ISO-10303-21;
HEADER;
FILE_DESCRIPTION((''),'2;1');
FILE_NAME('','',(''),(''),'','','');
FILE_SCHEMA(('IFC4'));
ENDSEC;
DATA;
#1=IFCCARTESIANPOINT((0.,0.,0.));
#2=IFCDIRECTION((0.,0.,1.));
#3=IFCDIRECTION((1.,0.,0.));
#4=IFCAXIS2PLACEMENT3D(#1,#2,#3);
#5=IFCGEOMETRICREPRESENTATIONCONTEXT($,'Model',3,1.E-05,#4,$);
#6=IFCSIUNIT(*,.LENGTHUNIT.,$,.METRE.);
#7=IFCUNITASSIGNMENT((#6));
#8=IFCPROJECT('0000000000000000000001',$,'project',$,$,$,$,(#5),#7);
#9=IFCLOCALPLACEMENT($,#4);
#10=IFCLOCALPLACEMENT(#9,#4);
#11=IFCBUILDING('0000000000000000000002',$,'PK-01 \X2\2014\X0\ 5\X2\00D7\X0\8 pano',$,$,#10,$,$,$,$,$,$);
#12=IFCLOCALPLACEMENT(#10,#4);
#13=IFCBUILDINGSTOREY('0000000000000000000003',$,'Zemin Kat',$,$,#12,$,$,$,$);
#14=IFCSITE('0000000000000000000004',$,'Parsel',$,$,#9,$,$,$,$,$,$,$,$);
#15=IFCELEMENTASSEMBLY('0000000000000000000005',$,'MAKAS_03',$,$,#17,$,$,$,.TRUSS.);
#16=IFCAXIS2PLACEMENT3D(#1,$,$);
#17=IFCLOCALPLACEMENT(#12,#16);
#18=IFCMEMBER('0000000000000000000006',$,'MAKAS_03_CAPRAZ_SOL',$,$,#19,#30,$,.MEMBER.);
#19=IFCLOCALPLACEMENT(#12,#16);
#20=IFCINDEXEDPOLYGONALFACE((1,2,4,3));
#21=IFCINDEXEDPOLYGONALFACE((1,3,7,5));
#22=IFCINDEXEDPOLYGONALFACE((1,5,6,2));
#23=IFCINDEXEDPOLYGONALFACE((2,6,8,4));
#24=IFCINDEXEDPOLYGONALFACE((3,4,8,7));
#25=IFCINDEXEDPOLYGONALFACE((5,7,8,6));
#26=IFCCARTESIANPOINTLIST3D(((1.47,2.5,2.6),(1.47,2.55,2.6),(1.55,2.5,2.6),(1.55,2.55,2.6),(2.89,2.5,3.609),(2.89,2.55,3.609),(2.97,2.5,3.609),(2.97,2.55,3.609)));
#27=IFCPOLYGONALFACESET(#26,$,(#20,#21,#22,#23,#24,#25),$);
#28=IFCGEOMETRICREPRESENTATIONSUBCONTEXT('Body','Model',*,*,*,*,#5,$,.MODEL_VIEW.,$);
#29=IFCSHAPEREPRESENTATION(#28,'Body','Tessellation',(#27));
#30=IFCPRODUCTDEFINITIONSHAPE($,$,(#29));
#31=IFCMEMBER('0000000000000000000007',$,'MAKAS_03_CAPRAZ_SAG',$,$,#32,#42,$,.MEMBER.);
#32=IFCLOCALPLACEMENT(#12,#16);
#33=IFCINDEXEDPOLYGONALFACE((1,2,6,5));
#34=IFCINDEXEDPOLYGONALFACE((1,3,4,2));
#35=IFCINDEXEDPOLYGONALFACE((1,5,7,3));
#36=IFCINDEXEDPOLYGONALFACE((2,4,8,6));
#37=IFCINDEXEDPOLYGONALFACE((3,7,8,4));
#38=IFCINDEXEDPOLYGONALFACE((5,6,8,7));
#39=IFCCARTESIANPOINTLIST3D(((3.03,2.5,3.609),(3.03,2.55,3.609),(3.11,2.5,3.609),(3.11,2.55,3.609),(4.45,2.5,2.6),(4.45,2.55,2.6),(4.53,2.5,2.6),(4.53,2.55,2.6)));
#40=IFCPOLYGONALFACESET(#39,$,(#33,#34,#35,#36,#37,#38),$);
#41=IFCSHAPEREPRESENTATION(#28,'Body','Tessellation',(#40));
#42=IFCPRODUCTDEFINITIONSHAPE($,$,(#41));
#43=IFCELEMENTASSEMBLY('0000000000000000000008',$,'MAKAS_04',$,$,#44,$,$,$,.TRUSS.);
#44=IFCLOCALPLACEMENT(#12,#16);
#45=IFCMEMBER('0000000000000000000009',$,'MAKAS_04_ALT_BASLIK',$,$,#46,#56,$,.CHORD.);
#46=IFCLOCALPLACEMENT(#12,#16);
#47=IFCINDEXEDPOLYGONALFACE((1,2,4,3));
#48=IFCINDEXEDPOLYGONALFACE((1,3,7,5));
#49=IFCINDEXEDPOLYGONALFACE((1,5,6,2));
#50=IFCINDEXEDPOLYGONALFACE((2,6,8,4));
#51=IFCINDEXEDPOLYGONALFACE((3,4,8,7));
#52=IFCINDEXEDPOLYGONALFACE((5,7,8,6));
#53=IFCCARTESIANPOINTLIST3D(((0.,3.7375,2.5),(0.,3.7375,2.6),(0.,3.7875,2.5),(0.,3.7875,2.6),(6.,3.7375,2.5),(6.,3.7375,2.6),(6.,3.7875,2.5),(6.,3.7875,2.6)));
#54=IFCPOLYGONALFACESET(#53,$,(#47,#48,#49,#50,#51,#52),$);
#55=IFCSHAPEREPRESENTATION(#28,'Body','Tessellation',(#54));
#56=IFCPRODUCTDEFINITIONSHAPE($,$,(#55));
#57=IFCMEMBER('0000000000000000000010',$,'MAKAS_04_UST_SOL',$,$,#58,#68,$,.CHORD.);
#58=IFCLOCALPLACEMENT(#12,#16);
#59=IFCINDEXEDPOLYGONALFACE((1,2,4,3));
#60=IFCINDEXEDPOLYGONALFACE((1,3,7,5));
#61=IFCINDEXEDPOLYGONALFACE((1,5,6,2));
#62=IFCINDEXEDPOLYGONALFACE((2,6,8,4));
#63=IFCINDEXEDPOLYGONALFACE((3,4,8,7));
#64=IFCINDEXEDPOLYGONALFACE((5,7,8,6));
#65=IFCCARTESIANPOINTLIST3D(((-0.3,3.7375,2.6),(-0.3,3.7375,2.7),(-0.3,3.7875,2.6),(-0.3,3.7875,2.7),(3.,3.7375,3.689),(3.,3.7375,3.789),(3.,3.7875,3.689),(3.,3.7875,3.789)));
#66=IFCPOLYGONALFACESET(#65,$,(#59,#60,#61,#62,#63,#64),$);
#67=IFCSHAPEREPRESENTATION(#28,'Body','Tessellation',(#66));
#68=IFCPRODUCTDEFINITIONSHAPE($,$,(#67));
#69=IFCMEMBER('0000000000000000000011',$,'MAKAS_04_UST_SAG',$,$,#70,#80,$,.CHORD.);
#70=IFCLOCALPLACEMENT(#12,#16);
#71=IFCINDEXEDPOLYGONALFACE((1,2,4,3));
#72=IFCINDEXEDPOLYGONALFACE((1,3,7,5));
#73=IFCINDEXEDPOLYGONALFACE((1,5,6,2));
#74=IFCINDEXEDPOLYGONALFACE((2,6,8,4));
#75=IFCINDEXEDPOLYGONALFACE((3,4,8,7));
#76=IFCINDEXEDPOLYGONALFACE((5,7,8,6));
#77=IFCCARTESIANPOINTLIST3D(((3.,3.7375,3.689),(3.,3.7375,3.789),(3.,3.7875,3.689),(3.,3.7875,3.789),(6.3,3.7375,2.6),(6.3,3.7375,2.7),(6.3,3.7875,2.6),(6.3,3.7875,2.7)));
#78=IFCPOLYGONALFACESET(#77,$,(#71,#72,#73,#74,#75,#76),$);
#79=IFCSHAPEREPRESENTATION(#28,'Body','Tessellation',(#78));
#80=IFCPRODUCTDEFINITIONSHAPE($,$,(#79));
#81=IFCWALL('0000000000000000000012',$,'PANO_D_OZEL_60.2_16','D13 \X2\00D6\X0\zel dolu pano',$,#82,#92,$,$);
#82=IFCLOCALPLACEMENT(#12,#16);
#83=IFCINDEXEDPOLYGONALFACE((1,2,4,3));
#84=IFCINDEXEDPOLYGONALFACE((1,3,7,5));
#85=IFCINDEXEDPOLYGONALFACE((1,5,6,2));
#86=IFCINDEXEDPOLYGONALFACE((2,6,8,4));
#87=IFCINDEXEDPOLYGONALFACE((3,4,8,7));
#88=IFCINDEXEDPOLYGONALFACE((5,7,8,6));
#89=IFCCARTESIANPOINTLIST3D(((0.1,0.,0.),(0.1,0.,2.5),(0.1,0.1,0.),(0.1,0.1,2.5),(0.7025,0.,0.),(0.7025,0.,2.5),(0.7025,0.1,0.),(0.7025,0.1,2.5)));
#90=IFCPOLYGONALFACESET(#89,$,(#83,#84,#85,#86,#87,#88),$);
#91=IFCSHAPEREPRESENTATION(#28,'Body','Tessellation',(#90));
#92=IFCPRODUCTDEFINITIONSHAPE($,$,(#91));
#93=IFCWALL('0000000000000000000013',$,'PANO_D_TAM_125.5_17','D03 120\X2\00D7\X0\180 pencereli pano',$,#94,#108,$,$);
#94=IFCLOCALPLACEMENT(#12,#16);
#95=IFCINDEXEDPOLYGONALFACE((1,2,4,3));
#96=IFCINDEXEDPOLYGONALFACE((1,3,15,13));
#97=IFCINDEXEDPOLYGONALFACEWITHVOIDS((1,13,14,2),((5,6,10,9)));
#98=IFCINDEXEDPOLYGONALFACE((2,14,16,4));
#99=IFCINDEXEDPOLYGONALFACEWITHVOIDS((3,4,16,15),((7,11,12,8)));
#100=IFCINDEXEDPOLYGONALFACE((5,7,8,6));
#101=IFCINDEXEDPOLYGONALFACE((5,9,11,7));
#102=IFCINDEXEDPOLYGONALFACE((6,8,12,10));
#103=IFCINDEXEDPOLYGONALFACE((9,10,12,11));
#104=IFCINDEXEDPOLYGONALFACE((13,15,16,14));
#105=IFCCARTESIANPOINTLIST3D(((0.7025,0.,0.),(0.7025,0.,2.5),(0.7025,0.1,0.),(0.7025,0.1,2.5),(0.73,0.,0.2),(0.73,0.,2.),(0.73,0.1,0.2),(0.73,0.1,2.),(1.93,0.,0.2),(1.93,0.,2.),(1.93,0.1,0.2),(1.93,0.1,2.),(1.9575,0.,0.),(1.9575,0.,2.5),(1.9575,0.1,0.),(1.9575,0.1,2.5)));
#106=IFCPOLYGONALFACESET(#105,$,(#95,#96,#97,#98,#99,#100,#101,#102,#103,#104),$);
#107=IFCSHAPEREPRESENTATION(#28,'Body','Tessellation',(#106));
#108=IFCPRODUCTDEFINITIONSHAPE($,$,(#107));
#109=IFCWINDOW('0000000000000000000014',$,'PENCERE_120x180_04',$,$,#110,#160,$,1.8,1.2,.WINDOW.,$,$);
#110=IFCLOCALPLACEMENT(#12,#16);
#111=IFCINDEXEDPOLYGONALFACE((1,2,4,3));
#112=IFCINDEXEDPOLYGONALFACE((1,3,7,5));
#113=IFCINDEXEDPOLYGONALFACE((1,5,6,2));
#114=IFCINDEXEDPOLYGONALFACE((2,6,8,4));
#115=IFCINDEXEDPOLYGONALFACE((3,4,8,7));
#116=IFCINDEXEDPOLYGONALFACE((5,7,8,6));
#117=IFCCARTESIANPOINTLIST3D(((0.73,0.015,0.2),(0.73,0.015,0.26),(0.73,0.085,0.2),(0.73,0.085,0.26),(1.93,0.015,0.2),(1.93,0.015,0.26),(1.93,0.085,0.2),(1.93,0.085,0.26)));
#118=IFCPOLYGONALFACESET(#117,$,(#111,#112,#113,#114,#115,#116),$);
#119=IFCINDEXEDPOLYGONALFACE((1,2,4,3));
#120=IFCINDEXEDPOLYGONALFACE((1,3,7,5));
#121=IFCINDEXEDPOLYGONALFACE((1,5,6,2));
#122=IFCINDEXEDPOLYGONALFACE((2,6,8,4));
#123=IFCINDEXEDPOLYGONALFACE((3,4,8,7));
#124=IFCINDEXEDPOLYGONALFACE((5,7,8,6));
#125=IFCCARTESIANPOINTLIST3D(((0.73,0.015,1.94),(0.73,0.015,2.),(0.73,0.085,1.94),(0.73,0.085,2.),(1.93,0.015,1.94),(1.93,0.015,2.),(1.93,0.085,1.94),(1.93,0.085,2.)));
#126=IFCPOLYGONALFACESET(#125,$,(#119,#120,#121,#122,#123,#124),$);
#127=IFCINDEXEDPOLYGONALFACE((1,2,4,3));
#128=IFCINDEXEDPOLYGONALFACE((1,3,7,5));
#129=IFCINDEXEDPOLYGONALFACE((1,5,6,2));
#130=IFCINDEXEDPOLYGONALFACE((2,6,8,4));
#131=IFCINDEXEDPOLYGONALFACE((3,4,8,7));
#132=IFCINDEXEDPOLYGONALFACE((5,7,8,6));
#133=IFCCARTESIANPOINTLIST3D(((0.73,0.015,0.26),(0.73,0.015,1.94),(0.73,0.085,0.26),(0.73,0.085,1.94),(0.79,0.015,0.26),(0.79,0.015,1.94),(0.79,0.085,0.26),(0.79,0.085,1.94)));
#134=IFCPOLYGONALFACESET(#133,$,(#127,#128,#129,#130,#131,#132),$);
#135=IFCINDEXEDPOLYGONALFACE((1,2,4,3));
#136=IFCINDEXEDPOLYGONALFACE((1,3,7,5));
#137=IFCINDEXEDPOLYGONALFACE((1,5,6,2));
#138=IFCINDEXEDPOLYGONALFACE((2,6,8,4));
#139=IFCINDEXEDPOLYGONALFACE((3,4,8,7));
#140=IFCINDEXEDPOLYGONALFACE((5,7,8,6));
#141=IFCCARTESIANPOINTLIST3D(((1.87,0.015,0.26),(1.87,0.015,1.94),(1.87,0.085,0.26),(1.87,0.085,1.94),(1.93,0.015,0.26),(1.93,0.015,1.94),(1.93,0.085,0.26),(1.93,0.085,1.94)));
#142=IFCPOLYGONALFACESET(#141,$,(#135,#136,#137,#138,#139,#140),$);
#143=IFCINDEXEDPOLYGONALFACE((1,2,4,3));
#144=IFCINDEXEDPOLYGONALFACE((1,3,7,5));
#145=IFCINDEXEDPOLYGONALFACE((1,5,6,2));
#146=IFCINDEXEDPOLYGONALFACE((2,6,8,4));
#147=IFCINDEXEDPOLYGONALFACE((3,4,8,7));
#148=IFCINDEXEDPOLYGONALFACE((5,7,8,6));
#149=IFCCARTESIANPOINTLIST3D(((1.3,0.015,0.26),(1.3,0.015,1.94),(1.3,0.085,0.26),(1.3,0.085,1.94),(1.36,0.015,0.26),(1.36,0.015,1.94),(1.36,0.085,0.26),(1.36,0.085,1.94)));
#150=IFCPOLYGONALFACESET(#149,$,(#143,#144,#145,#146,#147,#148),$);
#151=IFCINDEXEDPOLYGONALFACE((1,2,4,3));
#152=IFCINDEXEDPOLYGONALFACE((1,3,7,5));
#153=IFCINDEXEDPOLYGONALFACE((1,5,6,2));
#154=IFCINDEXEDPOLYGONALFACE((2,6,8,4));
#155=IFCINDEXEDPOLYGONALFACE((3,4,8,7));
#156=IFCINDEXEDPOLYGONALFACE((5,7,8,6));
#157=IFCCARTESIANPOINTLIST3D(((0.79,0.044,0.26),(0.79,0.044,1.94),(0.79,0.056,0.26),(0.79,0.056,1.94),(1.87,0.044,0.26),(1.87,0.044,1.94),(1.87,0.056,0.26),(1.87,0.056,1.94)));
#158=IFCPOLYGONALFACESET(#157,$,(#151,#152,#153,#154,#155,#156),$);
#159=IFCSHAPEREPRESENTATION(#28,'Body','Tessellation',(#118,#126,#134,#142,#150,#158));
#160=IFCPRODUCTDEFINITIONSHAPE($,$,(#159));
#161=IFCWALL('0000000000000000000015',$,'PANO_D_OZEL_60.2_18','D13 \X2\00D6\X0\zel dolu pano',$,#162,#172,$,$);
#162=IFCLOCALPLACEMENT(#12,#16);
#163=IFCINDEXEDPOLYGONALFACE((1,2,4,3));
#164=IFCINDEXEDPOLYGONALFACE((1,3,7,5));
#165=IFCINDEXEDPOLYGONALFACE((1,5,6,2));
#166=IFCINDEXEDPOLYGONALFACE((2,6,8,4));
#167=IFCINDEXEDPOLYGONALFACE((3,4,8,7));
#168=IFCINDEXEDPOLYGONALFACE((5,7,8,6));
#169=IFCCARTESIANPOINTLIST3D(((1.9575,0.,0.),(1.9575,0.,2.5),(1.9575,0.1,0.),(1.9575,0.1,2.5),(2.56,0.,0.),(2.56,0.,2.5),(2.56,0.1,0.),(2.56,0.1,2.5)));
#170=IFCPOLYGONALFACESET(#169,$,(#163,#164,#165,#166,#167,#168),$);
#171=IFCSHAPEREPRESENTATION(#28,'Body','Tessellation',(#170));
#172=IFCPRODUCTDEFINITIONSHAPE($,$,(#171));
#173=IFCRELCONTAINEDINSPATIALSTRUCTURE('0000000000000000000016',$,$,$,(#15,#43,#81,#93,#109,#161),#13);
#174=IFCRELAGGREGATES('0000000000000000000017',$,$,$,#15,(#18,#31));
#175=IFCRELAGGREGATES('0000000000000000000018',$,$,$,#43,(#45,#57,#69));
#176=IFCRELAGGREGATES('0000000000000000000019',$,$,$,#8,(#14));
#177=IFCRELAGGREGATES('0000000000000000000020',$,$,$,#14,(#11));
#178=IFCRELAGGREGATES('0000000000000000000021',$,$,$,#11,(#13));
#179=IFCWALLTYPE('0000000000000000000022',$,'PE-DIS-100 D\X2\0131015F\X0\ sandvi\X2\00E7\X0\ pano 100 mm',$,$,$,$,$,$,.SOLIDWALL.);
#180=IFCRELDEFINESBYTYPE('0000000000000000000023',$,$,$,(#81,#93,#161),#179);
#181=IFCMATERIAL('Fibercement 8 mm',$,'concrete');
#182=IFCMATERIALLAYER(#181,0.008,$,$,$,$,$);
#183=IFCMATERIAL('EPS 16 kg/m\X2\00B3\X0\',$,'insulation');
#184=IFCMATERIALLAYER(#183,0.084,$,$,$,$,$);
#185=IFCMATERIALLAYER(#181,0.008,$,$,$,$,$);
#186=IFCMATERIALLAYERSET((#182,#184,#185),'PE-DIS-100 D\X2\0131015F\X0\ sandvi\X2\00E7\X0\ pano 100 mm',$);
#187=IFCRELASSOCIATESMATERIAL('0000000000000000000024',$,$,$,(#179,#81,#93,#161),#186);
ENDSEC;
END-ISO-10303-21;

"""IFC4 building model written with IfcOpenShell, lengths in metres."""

from ifc_helpers import new_model, si_unit, frame, origin_with_axes, place, context, subcontext, project, spatial, line, indexed_curve, outline, extrude, material, layer, layer_set, layer_usage, type_object, element, fill, aggregate, save


model = new_model("IFC4")

# Units and contexts
model_context = context("Model", 3, precision=1e-05, world=origin_with_axes())
body_context = subcontext(model_context, "Body", "Model", "MODEL_VIEW")
ifc_project = project(units=[si_unit("LENGTHUNIT", "METRE")], contexts=[model_context])

# Site, building, storey
site_placement = place(None, origin_with_axes())
site = spatial("IfcSite", under=ifc_project, at=site_placement, Name="Parsel")
building_placement = place(site_placement, origin_with_axes())
building = spatial("IfcBuilding", under=site, at=building_placement, Name="PK-01 — 5×8 pano")
storey_placement = place(building_placement, origin_with_axes())
storey = spatial("IfcBuildingStorey", under=building, at=storey_placement, Name="Zemin Kat")

# Element assemblies, members
assembly_1_placement = place(storey_placement, origin_with_axes())
assembly_1 = element("IfcElementAssembly", 1, at=assembly_1_placement, inside=storey, Name="MAKAS_03", PredefinedType="TRUSS")
member_1_placement = place(assembly_1_placement, origin_with_axes())
member_1 = element("IfcMember", 2, at=member_1_placement, Name="MAKAS_03_CAPRAZ_SOL", PredefinedType="MEMBER", context=body_context, shape_type="SweptSolid", body=[
    extrude(outline(indexed_curve([(1.47, 2.6), (1.55, 2.6), (2.97, 3.609), (2.89, 3.609)], segments=[line(1, 2, 3, 4, 1)])), frame((0.0, 2.55, 0.0), z_axis=(0.0, -1.0, 0.0), x_axis=(1.0, 0.0, 0.0)), (0.0, 0.0, 1.0), 0.05),
])
member_2_placement = place(assembly_1_placement, origin_with_axes())
member_2 = element("IfcMember", 3, at=member_2_placement, Name="MAKAS_03_CAPRAZ_SAG", PredefinedType="MEMBER", context=body_context, shape_type="SweptSolid", body=[
    extrude(outline(indexed_curve([(4.45, 2.6), (4.53, 2.6), (3.11, 3.609), (3.03, 3.609)], segments=[line(1, 2, 3, 4, 1)])), frame((0.0, 2.55, 0.0), z_axis=(0.0, -1.0, 0.0), x_axis=(1.0, 0.0, 0.0)), (0.0, 0.0, 1.0), 0.05),
])
aggregate(assembly_1, [member_1, member_2])
assembly_2_placement = place(storey_placement, origin_with_axes())
assembly_2 = element("IfcElementAssembly", 4, at=assembly_2_placement, inside=storey, Name="MAKAS_04", PredefinedType="TRUSS")
member_3_placement = place(assembly_2_placement, origin_with_axes())
member_3 = element("IfcMember", 5, at=member_3_placement, Name="MAKAS_04_ALT_BASLIK", PredefinedType="CHORD", context=body_context, shape_type="SweptSolid", body=[
    extrude(outline(indexed_curve([(0.0, 2.5), (6.0, 2.5), (6.0, 2.6), (0.0, 2.6)], segments=[line(1, 2, 3, 4, 1)])), frame((0.0, 3.7875, 0.0), z_axis=(0.0, -1.0, 0.0), x_axis=(1.0, 0.0, 0.0)), (0.0, 0.0, 1.0), 0.05),
])
member_4_placement = place(assembly_2_placement, origin_with_axes())
member_4 = element("IfcMember", 6, at=member_4_placement, Name="MAKAS_04_UST_SOL", PredefinedType="CHORD", context=body_context, shape_type="SweptSolid", body=[
    extrude(outline(indexed_curve([(-0.3, 2.6), (3.0, 3.689), (3.0, 3.789), (-0.3, 2.7)], segments=[line(1, 2, 3, 4, 1)])), frame((0.0, 3.7875, 0.0), z_axis=(0.0, -1.0, 0.0), x_axis=(1.0, 0.0, 0.0)), (0.0, 0.0, 1.0), 0.05),
])
member_5_placement = place(assembly_2_placement, origin_with_axes())
member_5 = element("IfcMember", 7, at=member_5_placement, Name="MAKAS_04_UST_SAG", PredefinedType="CHORD", context=body_context, shape_type="SweptSolid", body=[
    extrude(outline(indexed_curve([(3.0, 3.689), (6.3, 2.6), (6.3, 2.7), (3.0, 3.789)], segments=[line(1, 2, 3, 4, 1)])), frame((0.0, 3.7875, 0.0), z_axis=(0.0, -1.0, 0.0), x_axis=(1.0, 0.0, 0.0)), (0.0, 0.0, 1.0), 0.05),
])
aggregate(assembly_2, [member_3, member_4, member_5])

# Wall
ifc_material_1 = material(Name="Fibercement 8 mm", Category="concrete")
ifc_layer_1 = layer(ifc_material_1, 0.008)
ifc_material_2 = material(Name="EPS 16 kg/m³", Category="insulation")
ifc_layer_2 = layer(ifc_material_2, 0.084)
ifc_layer_3 = layer(ifc_material_1, 0.008)
ifc_layer_set = layer_set([ifc_layer_1, ifc_layer_2, ifc_layer_3], Name="PE-DIS-100 Dış sandviç pano 100 mm")
ifc_layer_usage_1 = layer_usage(ifc_layer_set, "AXIS2", "POSITIVE", 0.0)
wall_type = type_object("IfcWallType", Name="PE-DIS-100 Dış sandviç pano 100 mm", PredefinedType="SOLIDWALL", material=ifc_layer_set)
wall_1_placement = place(storey_placement, frame((0.1, 0.0, 0.0), z_axis=(0.0, 0.0, 1.0), x_axis=(1.0, 0.0, 0.0)))
element("IfcWall", 8, at=wall_1_placement, inside=storey, type_object=wall_type, material=ifc_layer_usage_1, Name="PANO_D_OZEL_60.2_16", Description="D13 Özel dolu pano", context=body_context, shape_type="SweptSolid", body=[
    extrude(outline(indexed_curve([(0.0, 0.0), (0.6025, 0.0), (0.6025, 0.1), (0.0, 0.1)], segments=[line(1, 2, 3, 4, 1)])), origin_with_axes(), (0.0, 0.0, 1.0), 2.5),
])

# Wall, opening, window
ifc_layer_usage_2 = layer_usage(ifc_layer_set, "AXIS2", "POSITIVE", 0.0)
wall_2_placement = place(storey_placement, frame((0.7025, 0.0, 0.0), z_axis=(0.0, 0.0, 1.0), x_axis=(1.0, 0.0, 0.0)))
wall_2 = element("IfcWall", 9, at=wall_2_placement, inside=storey, type_object=wall_type, material=ifc_layer_usage_2, Name="PANO_D_TAM_125.5_17", Description="D03 120×180 pencereli pano", context=body_context, shape_type="SweptSolid", body=[
    extrude(outline(indexed_curve([(0.0, 0.0), (1.255, 0.0), (1.255, 0.1), (0.0, 0.1)], segments=[line(1, 2, 3, 4, 1)])), origin_with_axes(), (0.0, 0.0, 1.0), 2.5),
])
opening_placement = place(wall_2_placement, origin_with_axes())
opening = element("IfcOpeningElement", 10, at=opening_placement, cuts=wall_2, PredefinedType="OPENING", context=body_context, shape_type="SweptSolid", body=[
    extrude(outline(indexed_curve([(0.0, 0.0), (1.2, 0.0), (1.2, 0.14), (0.0, 0.14)], segments=[line(1, 2, 3, 4, 1)])), frame((0.0275, -0.02, 0.2), z_axis=(0.0, 0.0, 1.0), x_axis=(1.0, 0.0, 0.0)), (0.0, 0.0, 1.0), 1.8),
])
window_placement = place(storey_placement, frame((0.7025, 0.0, 0.0), z_axis=(0.0, 0.0, 1.0), x_axis=(1.0, 0.0, 0.0)))
window = element("IfcWindow", 11, at=window_placement, inside=storey, Name="PENCERE_120x180_04", OverallHeight=1.8, OverallWidth=1.2, PredefinedType="WINDOW", context=body_context, shape_type="SweptSolid", body=[
    extrude(outline(indexed_curve([(0.0, 0.0), (1.2, 0.0), (1.2, 0.07), (0.0, 0.07)], segments=[line(1, 2, 3, 4, 1)])), frame((0.0275, 0.015, 0.2), z_axis=(0.0, 0.0, 1.0), x_axis=(1.0, 0.0, 0.0)), (0.0, 0.0, 1.0), 0.06),
    extrude(outline(indexed_curve([(0.0, 0.0), (1.2, 0.0), (1.2, 0.07), (0.0, 0.07)], segments=[line(1, 2, 3, 4, 1)])), frame((0.0275, 0.015, 1.94), z_axis=(0.0, 0.0, 1.0), x_axis=(1.0, 0.0, 0.0)), (0.0, 0.0, 1.0), 0.06),
    extrude(outline(indexed_curve([(0.0, 0.0), (0.06, 0.0), (0.06, 0.07), (0.0, 0.07)], segments=[line(1, 2, 3, 4, 1)])), frame((0.0275, 0.015, 0.26), z_axis=(0.0, 0.0, 1.0), x_axis=(1.0, 0.0, 0.0)), (0.0, 0.0, 1.0), 1.68),
    extrude(outline(indexed_curve([(0.0, 0.0), (0.06, 0.0), (0.06, 0.07), (0.0, 0.07)], segments=[line(1, 2, 3, 4, 1)])), frame((1.1675, 0.015, 0.26), z_axis=(0.0, 0.0, 1.0), x_axis=(1.0, 0.0, 0.0)), (0.0, 0.0, 1.0), 1.68),
    extrude(outline(indexed_curve([(0.0, 0.0), (0.06, 0.0), (0.06, 0.07), (0.0, 0.07)], segments=[line(1, 2, 3, 4, 1)])), frame((0.5975, 0.015, 0.26), z_axis=(0.0, 0.0, 1.0), x_axis=(1.0, 0.0, 0.0)), (0.0, 0.0, 1.0), 1.68),
    extrude(outline(indexed_curve([(0.0, 0.0), (1.08, 0.0), (1.08, 0.012), (0.0, 0.012)], segments=[line(1, 2, 3, 4, 1)])), frame((0.0875, 0.044, 0.26), z_axis=(0.0, 0.0, 1.0), x_axis=(1.0, 0.0, 0.0)), (0.0, 0.0, 1.0), 1.68),
])
fill(opening, window)

# Wall
ifc_layer_usage_3 = layer_usage(ifc_layer_set, "AXIS2", "POSITIVE", 0.0)
wall_3_placement = place(storey_placement, frame((1.9575, 0.0, 0.0), z_axis=(0.0, 0.0, 1.0), x_axis=(1.0, 0.0, 0.0)))
element("IfcWall", 12, at=wall_3_placement, inside=storey, type_object=wall_type, material=ifc_layer_usage_3, Name="PANO_D_OZEL_60.2_18", Description="D13 Özel dolu pano", context=body_context, shape_type="SweptSolid", body=[
    extrude(outline(indexed_curve([(0.0, 0.0), (0.6025, 0.0), (0.6025, 0.1), (0.0, 0.1)], segments=[line(1, 2, 3, 4, 1)])), origin_with_axes(), (0.0, 0.0, 1.0), 2.5),
])

save(model, "model.ifc")
